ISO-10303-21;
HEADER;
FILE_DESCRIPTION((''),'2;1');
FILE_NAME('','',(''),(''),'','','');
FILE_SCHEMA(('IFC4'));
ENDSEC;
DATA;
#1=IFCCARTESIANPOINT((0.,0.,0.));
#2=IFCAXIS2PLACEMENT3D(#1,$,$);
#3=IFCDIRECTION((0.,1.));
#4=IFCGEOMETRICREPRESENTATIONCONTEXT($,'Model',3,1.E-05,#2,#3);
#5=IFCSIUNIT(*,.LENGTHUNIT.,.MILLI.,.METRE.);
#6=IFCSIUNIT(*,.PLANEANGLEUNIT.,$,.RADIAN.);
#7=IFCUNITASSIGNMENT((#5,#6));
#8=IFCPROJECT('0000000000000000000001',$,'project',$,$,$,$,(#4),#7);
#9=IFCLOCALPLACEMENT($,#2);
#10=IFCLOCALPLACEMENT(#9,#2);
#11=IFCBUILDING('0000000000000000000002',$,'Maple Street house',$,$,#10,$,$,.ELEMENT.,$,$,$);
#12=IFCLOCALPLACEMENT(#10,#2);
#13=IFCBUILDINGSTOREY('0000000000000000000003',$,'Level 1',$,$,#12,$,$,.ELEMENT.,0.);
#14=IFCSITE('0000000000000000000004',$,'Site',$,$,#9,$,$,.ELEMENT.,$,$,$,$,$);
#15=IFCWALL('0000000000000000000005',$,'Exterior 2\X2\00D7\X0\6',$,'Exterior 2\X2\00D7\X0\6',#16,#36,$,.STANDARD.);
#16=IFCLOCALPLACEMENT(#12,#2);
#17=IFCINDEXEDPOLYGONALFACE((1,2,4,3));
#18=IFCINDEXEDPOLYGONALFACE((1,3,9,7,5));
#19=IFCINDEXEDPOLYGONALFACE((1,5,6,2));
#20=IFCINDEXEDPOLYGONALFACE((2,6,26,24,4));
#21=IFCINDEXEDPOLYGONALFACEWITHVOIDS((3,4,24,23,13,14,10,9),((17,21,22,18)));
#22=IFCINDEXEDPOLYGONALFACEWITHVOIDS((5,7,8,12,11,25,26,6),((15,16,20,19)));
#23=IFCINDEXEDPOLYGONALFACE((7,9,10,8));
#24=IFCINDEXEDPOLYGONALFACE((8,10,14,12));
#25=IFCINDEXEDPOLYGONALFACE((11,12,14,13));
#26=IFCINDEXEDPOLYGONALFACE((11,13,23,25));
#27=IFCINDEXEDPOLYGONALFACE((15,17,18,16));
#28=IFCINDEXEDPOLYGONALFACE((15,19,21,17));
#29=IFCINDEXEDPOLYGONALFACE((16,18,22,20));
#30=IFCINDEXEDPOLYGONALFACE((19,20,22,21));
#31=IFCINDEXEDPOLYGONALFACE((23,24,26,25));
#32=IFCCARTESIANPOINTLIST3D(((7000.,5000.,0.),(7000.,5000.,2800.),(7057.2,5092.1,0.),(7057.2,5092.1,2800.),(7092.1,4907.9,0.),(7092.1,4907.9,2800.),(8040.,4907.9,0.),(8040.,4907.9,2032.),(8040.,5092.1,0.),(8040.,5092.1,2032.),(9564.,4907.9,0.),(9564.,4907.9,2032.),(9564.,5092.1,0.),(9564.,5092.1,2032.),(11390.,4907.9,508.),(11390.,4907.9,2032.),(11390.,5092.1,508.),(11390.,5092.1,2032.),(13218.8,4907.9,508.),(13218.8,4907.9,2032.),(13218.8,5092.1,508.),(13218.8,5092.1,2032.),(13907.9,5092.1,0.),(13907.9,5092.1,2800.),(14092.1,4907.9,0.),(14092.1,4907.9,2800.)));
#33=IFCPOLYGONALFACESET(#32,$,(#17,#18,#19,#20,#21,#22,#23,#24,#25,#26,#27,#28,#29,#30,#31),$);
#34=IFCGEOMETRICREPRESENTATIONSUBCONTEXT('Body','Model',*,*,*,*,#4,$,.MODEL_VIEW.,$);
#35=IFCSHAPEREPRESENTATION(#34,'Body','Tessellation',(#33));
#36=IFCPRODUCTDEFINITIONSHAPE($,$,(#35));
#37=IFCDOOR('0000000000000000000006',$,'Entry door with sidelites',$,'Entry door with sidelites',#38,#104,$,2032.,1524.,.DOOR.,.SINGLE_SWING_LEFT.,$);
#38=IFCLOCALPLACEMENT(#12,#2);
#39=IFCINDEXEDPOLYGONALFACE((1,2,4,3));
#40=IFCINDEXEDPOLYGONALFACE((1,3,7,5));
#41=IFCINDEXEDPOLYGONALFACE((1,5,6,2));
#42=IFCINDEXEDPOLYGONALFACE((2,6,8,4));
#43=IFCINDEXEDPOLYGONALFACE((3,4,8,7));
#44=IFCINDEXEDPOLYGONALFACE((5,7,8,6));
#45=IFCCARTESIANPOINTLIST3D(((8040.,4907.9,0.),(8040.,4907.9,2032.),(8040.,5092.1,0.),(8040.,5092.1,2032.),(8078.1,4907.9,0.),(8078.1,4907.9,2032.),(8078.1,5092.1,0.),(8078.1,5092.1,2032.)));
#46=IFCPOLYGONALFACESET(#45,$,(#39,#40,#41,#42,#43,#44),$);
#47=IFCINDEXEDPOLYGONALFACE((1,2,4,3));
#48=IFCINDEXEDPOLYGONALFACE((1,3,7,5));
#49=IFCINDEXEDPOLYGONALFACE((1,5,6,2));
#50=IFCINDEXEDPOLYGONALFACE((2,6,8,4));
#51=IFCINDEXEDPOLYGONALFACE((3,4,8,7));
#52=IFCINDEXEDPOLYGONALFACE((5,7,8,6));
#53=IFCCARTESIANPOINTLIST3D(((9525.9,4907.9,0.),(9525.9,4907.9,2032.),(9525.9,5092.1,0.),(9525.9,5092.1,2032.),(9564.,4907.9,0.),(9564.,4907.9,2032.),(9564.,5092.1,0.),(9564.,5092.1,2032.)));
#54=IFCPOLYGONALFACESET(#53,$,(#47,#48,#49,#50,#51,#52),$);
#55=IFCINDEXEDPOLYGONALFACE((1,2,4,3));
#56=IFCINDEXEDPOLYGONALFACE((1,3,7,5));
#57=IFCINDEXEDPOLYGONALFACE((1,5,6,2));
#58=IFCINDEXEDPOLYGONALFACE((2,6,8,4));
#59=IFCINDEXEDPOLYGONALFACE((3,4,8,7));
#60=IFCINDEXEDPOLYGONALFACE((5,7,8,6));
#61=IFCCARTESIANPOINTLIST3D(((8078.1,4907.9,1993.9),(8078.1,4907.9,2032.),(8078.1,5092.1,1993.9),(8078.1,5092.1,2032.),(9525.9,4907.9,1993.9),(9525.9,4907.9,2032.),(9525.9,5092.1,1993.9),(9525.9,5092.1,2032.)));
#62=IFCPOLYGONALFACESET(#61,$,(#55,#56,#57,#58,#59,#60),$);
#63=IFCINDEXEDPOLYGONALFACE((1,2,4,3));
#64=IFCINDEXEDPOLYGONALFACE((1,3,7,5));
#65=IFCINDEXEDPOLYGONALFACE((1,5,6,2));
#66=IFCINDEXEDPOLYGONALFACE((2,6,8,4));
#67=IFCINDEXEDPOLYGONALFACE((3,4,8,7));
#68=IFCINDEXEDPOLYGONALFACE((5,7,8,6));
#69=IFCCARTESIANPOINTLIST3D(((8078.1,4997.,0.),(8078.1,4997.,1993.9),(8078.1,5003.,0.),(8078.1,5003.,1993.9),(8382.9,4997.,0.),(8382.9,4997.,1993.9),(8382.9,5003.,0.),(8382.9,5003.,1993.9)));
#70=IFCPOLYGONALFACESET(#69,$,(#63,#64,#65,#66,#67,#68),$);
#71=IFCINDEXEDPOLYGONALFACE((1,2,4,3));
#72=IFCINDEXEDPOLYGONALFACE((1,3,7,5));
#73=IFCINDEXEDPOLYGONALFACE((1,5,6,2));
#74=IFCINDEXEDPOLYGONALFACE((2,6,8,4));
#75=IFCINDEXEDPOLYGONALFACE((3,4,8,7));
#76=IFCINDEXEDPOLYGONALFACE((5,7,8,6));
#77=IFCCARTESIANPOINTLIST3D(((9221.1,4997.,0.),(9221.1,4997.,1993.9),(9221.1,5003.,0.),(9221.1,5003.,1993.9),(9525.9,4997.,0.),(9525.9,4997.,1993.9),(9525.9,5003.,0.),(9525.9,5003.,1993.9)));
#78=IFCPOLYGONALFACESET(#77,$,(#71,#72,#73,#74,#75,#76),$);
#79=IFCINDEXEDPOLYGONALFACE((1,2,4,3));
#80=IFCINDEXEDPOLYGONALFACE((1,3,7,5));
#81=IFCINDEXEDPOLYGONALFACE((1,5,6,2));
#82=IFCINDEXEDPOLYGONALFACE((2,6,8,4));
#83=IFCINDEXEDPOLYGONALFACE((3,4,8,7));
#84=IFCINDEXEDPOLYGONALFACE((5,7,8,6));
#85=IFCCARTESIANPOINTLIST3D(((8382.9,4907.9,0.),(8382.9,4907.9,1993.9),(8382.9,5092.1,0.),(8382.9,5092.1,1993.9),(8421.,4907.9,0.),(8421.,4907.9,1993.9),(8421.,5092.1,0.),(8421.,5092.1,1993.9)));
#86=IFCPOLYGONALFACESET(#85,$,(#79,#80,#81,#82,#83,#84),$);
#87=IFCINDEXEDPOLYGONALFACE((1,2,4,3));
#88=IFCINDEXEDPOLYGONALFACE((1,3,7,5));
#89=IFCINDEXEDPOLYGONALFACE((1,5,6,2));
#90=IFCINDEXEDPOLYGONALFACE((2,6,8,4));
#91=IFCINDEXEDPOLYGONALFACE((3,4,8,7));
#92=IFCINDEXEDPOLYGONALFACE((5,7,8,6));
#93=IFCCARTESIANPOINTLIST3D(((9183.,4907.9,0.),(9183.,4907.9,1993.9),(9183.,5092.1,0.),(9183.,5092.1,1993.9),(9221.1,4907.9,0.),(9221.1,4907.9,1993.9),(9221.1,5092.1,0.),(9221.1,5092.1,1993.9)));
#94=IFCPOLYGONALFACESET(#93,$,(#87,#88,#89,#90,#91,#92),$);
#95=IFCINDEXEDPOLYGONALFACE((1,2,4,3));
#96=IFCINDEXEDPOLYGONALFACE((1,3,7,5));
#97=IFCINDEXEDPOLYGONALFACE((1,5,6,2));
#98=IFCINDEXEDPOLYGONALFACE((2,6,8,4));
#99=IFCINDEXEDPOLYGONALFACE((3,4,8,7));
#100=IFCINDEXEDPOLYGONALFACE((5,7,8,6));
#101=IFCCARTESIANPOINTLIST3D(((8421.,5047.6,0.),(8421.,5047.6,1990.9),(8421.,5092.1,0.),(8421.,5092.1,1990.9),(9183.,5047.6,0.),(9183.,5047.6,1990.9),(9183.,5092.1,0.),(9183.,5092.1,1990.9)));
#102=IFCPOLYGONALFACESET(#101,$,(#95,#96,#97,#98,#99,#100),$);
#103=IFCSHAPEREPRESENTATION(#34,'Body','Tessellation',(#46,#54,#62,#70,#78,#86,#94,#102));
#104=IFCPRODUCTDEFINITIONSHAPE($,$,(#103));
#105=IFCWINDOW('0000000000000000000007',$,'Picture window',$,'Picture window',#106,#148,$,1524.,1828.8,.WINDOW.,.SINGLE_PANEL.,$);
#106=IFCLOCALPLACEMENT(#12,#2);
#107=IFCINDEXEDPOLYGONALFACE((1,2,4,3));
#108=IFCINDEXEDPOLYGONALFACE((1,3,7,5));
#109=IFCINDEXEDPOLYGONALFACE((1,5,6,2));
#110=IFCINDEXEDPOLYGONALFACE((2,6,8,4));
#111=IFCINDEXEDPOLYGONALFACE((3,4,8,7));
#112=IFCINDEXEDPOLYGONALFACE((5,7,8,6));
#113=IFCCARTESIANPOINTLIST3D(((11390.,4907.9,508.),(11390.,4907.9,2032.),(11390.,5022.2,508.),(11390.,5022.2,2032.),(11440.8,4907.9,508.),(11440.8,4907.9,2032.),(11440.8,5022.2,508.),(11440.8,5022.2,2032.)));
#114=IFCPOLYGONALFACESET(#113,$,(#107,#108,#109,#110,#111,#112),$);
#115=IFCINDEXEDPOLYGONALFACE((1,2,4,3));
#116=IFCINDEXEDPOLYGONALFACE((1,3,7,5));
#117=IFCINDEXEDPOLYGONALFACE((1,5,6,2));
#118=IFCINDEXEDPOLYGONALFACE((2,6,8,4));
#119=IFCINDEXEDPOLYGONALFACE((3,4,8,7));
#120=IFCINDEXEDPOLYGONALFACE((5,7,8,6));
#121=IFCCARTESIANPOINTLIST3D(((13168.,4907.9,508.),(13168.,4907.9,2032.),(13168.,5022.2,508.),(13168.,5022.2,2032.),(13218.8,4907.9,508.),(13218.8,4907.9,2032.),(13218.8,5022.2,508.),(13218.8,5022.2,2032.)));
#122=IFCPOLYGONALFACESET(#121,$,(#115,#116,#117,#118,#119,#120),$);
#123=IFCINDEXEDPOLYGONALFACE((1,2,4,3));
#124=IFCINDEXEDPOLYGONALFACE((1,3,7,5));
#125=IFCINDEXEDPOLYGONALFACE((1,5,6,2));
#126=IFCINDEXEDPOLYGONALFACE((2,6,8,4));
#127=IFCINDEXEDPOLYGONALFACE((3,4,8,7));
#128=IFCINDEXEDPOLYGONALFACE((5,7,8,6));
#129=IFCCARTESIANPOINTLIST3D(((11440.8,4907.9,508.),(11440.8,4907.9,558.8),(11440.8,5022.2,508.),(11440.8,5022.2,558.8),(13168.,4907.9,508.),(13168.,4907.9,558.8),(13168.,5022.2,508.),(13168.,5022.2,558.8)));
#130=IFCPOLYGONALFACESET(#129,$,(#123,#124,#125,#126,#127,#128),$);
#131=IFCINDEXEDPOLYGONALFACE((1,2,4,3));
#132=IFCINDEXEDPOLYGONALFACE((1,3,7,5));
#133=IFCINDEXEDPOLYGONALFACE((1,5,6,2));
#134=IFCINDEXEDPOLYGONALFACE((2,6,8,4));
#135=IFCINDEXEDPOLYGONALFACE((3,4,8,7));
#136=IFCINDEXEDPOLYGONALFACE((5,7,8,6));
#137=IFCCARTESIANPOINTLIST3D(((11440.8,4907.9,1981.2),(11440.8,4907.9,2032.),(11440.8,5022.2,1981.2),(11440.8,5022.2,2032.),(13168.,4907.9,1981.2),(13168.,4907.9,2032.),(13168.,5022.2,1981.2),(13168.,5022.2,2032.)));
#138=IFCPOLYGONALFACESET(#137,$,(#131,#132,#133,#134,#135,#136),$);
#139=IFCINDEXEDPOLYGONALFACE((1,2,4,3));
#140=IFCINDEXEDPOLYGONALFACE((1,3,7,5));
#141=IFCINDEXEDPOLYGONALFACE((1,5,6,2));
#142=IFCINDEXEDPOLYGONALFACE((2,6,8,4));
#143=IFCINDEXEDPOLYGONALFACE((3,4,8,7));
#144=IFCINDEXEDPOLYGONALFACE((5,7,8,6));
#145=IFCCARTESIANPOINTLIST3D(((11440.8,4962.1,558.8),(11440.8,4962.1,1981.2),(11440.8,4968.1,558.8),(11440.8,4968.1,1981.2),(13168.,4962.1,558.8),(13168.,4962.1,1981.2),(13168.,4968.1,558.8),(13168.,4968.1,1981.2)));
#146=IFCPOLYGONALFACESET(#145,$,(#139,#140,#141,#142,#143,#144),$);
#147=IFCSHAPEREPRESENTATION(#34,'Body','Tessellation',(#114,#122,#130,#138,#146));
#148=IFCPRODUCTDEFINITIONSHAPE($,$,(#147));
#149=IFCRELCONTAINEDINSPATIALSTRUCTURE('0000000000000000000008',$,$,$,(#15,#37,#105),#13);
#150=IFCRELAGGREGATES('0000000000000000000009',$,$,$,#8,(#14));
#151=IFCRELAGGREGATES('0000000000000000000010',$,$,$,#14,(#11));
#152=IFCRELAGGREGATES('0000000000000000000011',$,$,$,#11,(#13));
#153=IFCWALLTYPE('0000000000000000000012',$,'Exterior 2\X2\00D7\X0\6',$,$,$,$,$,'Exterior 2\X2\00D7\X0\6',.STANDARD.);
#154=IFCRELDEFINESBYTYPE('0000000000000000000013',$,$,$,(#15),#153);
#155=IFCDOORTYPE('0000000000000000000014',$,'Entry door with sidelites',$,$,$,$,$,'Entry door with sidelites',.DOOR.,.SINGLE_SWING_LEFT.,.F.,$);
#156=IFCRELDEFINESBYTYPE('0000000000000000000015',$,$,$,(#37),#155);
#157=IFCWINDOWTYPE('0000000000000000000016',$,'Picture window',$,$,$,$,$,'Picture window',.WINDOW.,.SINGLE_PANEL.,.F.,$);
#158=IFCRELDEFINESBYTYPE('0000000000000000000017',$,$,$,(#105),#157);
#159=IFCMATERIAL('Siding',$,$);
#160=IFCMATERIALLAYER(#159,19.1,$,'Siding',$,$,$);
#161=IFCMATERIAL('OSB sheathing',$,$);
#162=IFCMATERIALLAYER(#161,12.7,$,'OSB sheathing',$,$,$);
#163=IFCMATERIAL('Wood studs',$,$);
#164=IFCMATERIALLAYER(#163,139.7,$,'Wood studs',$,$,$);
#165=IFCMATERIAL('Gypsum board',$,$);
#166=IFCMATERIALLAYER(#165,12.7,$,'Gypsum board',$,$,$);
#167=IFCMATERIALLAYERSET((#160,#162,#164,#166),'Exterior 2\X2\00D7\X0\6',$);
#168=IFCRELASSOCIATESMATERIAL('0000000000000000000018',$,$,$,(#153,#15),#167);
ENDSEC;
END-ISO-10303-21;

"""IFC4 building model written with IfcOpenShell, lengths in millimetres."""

from ifc_helpers import new_model, si_unit, direction, frame, origin, origin_with_axes, place, context, subcontext, project, spatial, polyline, outline, extrude, material, layer, layer_set, layer_usage, type_object, element, fill, save


model = new_model("IFC4")

# Units and contexts
model_context = context("Model", 3, precision=1e-05, world=origin(), true_north=direction((0.0, 1.0)))
body_context = subcontext(model_context, "Body", "Model", "MODEL_VIEW")
ifc_project = project(units=[si_unit("LENGTHUNIT", "METRE", prefix="MILLI"), si_unit("PLANEANGLEUNIT", "RADIAN")], contexts=[model_context])

# Site, building, storey
site_placement = place(None, origin())
site = spatial("IfcSite", under=ifc_project, at=site_placement, Name="Site", CompositionType="ELEMENT")
building_placement = place(site_placement, origin())
building = spatial("IfcBuilding", under=site, at=building_placement, Name="Maple Street house", CompositionType="ELEMENT")
storey_placement = place(building_placement, origin())
storey = spatial("IfcBuildingStorey", under=building, at=storey_placement, Name="Level 1", CompositionType="ELEMENT", Elevation=0.0)

# Shared definitions
ifc_material_1 = material(Name="Siding")
ifc_layer_1 = layer(ifc_material_1, 19.1, Name="Siding")
ifc_material_2 = material(Name="OSB sheathing")
ifc_layer_2 = layer(ifc_material_2, 12.7, Name="OSB sheathing")
ifc_material_3 = material(Name="Wood studs")
ifc_layer_3 = layer(ifc_material_3, 139.7, Name="Wood studs")
ifc_material_4 = material(Name="Gypsum board")
ifc_layer_4 = layer(ifc_material_4, 12.7, Name="Gypsum board")
ifc_layer_set_1 = layer_set([ifc_layer_1, ifc_layer_2, ifc_layer_3, ifc_layer_4], Name="Exterior 2×6")
wall_type_1 = type_object("IfcWallType", Name="Exterior 2×6", ElementType="Exterior 2×6", PredefinedType="STANDARD", material=ifc_layer_set_1)

# Wall, openings, door, window
ifc_layer_usage_1 = layer_usage(ifc_layer_set_1, "AXIS2", "POSITIVE", -92.1)
wall_1_placement = place(storey_placement, frame((7000.0, 5000.0, 0.0), z_axis=(0.0, 0.0, 1.0), x_axis=(1.0, 0.0, 0.0)))
wall_1 = element("IfcWall", 1, at=wall_1_placement, inside=storey, type_object=wall_type_1, material=ifc_layer_usage_1, Name="Exterior 2×6", ObjectType="Exterior 2×6", PredefinedType="STANDARD", context=body_context, shape_type="SweptSolid", body=[
    extrude(outline(polyline([(92.1, -92.1), (7092.1, -92.1), (6907.9, 92.1), (57.1, 92.1), (0.0, 0.0), (92.1, -92.1)])), origin(), (0.0, 0.0, 1.0), 2800.0),
])
opening_1_placement = place(wall_1_placement, frame((1040.0, 0.0, 0.0), z_axis=(0.0, 0.0, 1.0), x_axis=(1.0, 0.0, 0.0)))
opening_1 = element("IfcOpeningElement", 2, at=opening_1_placement, cuts=wall_1, PredefinedType="OPENING", context=body_context, shape_type="SweptSolid", body=[
    extrude(outline(polyline([(0.0, -102.1), (1524.0, -102.1), (1524.0, 102.1), (0.0, 102.1), (0.0, -102.1)])), origin(), (0.0, 0.0, 1.0), 2032.0),
])
opening_2_placement = place(wall_1_placement, frame((4390.0, 0.0, 508.0), z_axis=(0.0, 0.0, 1.0), x_axis=(1.0, 0.0, 0.0)))
opening_2 = element("IfcOpeningElement", 3, at=opening_2_placement, cuts=wall_1, PredefinedType="OPENING", context=body_context, shape_type="SweptSolid", body=[
    extrude(outline(polyline([(0.0, -102.1), (1828.8, -102.1), (1828.8, 102.1), (0.0, 102.1), (0.0, -102.1)])), origin(), (0.0, 0.0, 1.0), 1524.0),
])
door_type_1 = type_object("IfcDoorType", Name="Entry door with sidelites", ElementType="Entry door with sidelites", OperationType="SINGLE_SWING_LEFT", ParameterTakesPrecedence=False, PredefinedType="DOOR")
door_1_placement = place(opening_1_placement, origin_with_axes())
door_1 = element("IfcDoor", 4, at=door_1_placement, inside=storey, type_object=door_type_1, Name="Entry door with sidelites", ObjectType="Entry door with sidelites", OperationType="SINGLE_SWING_LEFT", OverallHeight=2032.0, OverallWidth=1524.0, PredefinedType="DOOR", context=body_context, shape_type="SweptSolid", body=[
    extrude(outline(polyline([(0.0, -92.1), (38.1, -92.1), (38.1, 92.1), (0.0, 92.1), (0.0, -92.1)])), origin(), (0.0, 0.0, 1.0), 2032.0),
    extrude(outline(polyline([(1485.9, -92.1), (1524.0, -92.1), (1524.0, 92.1), (1485.9, 92.1), (1485.9, -92.1)])), origin(), (0.0, 0.0, 1.0), 2032.0),
    extrude(outline(polyline([(38.1, -92.1), (1485.9, -92.1), (1485.9, 92.1), (38.1, 92.1), (38.1, -92.1)])), frame((0.0, 0.0, 1993.9)), (0.0, 0.0, 1.0), 38.1),
    extrude(outline(polyline([(38.1, -3.0), (342.9, -3.0), (342.9, 3.0), (38.1, 3.0), (38.1, -3.0)])), origin(), (0.0, 0.0, 1.0), 1993.9),
    extrude(outline(polyline([(1181.1, -3.0), (1485.9, -3.0), (1485.9, 3.0), (1181.1, 3.0), (1181.1, -3.0)])), origin(), (0.0, 0.0, 1.0), 1993.9),
    extrude(outline(polyline([(342.9, -92.1), (381.0, -92.1), (381.0, 92.1), (342.9, 92.1), (342.9, -92.1)])), origin(), (0.0, 0.0, 1.0), 1993.9),
    extrude(outline(polyline([(1143.0, -92.1), (1181.1, -92.1), (1181.1, 92.1), (1143.0, 92.1), (1143.0, -92.1)])), origin(), (0.0, 0.0, 1.0), 1993.9),
    extrude(outline(polyline([(381.0, 47.6), (1143.0, 47.6), (1143.0, 92.1), (381.0, 92.1), (381.0, 47.6)])), origin(), (0.0, 0.0, 1.0), 1990.9),
])
fill(opening_1, door_1)
window_type_1 = type_object("IfcWindowType", Name="Picture window", ElementType="Picture window", ParameterTakesPrecedence=False, PartitioningType="SINGLE_PANEL", PredefinedType="WINDOW")
window_1_placement = place(opening_2_placement, origin_with_axes())
window_1 = element("IfcWindow", 5, at=window_1_placement, inside=storey, type_object=window_type_1, Name="Picture window", ObjectType="Picture window", OverallHeight=1524.0, OverallWidth=1828.8, PartitioningType="SINGLE_PANEL", PredefinedType="WINDOW", context=body_context, shape_type="SweptSolid", body=[
    extrude(outline(polyline([(0.0, -92.1), (50.8, -92.1), (50.8, 22.2), (0.0, 22.2), (0.0, -92.1)])), origin(), (0.0, 0.0, 1.0), 1524.0),
    extrude(outline(polyline([(1778.0, -92.1), (1828.8, -92.1), (1828.8, 22.2), (1778.0, 22.2), (1778.0, -92.1)])), origin(), (0.0, 0.0, 1.0), 1524.0),
    extrude(outline(polyline([(50.8, -92.1), (1778.0, -92.1), (1778.0, 22.2), (50.8, 22.2), (50.8, -92.1)])), origin(), (0.0, 0.0, 1.0), 50.8),
    extrude(outline(polyline([(50.8, -92.1), (1778.0, -92.1), (1778.0, 22.2), (50.8, 22.2), (50.8, -92.1)])), frame((0.0, 0.0, 1473.2)), (0.0, 0.0, 1.0), 50.8),
    extrude(outline(polyline([(50.8, -37.9), (1778.0, -37.9), (1778.0, -31.9), (50.8, -31.9), (50.8, -37.9)])), frame((0.0, 0.0, 50.8)), (0.0, 0.0, 1.0), 1422.4),
])
fill(opening_2, window_1)

save(model, "model.ifc")
